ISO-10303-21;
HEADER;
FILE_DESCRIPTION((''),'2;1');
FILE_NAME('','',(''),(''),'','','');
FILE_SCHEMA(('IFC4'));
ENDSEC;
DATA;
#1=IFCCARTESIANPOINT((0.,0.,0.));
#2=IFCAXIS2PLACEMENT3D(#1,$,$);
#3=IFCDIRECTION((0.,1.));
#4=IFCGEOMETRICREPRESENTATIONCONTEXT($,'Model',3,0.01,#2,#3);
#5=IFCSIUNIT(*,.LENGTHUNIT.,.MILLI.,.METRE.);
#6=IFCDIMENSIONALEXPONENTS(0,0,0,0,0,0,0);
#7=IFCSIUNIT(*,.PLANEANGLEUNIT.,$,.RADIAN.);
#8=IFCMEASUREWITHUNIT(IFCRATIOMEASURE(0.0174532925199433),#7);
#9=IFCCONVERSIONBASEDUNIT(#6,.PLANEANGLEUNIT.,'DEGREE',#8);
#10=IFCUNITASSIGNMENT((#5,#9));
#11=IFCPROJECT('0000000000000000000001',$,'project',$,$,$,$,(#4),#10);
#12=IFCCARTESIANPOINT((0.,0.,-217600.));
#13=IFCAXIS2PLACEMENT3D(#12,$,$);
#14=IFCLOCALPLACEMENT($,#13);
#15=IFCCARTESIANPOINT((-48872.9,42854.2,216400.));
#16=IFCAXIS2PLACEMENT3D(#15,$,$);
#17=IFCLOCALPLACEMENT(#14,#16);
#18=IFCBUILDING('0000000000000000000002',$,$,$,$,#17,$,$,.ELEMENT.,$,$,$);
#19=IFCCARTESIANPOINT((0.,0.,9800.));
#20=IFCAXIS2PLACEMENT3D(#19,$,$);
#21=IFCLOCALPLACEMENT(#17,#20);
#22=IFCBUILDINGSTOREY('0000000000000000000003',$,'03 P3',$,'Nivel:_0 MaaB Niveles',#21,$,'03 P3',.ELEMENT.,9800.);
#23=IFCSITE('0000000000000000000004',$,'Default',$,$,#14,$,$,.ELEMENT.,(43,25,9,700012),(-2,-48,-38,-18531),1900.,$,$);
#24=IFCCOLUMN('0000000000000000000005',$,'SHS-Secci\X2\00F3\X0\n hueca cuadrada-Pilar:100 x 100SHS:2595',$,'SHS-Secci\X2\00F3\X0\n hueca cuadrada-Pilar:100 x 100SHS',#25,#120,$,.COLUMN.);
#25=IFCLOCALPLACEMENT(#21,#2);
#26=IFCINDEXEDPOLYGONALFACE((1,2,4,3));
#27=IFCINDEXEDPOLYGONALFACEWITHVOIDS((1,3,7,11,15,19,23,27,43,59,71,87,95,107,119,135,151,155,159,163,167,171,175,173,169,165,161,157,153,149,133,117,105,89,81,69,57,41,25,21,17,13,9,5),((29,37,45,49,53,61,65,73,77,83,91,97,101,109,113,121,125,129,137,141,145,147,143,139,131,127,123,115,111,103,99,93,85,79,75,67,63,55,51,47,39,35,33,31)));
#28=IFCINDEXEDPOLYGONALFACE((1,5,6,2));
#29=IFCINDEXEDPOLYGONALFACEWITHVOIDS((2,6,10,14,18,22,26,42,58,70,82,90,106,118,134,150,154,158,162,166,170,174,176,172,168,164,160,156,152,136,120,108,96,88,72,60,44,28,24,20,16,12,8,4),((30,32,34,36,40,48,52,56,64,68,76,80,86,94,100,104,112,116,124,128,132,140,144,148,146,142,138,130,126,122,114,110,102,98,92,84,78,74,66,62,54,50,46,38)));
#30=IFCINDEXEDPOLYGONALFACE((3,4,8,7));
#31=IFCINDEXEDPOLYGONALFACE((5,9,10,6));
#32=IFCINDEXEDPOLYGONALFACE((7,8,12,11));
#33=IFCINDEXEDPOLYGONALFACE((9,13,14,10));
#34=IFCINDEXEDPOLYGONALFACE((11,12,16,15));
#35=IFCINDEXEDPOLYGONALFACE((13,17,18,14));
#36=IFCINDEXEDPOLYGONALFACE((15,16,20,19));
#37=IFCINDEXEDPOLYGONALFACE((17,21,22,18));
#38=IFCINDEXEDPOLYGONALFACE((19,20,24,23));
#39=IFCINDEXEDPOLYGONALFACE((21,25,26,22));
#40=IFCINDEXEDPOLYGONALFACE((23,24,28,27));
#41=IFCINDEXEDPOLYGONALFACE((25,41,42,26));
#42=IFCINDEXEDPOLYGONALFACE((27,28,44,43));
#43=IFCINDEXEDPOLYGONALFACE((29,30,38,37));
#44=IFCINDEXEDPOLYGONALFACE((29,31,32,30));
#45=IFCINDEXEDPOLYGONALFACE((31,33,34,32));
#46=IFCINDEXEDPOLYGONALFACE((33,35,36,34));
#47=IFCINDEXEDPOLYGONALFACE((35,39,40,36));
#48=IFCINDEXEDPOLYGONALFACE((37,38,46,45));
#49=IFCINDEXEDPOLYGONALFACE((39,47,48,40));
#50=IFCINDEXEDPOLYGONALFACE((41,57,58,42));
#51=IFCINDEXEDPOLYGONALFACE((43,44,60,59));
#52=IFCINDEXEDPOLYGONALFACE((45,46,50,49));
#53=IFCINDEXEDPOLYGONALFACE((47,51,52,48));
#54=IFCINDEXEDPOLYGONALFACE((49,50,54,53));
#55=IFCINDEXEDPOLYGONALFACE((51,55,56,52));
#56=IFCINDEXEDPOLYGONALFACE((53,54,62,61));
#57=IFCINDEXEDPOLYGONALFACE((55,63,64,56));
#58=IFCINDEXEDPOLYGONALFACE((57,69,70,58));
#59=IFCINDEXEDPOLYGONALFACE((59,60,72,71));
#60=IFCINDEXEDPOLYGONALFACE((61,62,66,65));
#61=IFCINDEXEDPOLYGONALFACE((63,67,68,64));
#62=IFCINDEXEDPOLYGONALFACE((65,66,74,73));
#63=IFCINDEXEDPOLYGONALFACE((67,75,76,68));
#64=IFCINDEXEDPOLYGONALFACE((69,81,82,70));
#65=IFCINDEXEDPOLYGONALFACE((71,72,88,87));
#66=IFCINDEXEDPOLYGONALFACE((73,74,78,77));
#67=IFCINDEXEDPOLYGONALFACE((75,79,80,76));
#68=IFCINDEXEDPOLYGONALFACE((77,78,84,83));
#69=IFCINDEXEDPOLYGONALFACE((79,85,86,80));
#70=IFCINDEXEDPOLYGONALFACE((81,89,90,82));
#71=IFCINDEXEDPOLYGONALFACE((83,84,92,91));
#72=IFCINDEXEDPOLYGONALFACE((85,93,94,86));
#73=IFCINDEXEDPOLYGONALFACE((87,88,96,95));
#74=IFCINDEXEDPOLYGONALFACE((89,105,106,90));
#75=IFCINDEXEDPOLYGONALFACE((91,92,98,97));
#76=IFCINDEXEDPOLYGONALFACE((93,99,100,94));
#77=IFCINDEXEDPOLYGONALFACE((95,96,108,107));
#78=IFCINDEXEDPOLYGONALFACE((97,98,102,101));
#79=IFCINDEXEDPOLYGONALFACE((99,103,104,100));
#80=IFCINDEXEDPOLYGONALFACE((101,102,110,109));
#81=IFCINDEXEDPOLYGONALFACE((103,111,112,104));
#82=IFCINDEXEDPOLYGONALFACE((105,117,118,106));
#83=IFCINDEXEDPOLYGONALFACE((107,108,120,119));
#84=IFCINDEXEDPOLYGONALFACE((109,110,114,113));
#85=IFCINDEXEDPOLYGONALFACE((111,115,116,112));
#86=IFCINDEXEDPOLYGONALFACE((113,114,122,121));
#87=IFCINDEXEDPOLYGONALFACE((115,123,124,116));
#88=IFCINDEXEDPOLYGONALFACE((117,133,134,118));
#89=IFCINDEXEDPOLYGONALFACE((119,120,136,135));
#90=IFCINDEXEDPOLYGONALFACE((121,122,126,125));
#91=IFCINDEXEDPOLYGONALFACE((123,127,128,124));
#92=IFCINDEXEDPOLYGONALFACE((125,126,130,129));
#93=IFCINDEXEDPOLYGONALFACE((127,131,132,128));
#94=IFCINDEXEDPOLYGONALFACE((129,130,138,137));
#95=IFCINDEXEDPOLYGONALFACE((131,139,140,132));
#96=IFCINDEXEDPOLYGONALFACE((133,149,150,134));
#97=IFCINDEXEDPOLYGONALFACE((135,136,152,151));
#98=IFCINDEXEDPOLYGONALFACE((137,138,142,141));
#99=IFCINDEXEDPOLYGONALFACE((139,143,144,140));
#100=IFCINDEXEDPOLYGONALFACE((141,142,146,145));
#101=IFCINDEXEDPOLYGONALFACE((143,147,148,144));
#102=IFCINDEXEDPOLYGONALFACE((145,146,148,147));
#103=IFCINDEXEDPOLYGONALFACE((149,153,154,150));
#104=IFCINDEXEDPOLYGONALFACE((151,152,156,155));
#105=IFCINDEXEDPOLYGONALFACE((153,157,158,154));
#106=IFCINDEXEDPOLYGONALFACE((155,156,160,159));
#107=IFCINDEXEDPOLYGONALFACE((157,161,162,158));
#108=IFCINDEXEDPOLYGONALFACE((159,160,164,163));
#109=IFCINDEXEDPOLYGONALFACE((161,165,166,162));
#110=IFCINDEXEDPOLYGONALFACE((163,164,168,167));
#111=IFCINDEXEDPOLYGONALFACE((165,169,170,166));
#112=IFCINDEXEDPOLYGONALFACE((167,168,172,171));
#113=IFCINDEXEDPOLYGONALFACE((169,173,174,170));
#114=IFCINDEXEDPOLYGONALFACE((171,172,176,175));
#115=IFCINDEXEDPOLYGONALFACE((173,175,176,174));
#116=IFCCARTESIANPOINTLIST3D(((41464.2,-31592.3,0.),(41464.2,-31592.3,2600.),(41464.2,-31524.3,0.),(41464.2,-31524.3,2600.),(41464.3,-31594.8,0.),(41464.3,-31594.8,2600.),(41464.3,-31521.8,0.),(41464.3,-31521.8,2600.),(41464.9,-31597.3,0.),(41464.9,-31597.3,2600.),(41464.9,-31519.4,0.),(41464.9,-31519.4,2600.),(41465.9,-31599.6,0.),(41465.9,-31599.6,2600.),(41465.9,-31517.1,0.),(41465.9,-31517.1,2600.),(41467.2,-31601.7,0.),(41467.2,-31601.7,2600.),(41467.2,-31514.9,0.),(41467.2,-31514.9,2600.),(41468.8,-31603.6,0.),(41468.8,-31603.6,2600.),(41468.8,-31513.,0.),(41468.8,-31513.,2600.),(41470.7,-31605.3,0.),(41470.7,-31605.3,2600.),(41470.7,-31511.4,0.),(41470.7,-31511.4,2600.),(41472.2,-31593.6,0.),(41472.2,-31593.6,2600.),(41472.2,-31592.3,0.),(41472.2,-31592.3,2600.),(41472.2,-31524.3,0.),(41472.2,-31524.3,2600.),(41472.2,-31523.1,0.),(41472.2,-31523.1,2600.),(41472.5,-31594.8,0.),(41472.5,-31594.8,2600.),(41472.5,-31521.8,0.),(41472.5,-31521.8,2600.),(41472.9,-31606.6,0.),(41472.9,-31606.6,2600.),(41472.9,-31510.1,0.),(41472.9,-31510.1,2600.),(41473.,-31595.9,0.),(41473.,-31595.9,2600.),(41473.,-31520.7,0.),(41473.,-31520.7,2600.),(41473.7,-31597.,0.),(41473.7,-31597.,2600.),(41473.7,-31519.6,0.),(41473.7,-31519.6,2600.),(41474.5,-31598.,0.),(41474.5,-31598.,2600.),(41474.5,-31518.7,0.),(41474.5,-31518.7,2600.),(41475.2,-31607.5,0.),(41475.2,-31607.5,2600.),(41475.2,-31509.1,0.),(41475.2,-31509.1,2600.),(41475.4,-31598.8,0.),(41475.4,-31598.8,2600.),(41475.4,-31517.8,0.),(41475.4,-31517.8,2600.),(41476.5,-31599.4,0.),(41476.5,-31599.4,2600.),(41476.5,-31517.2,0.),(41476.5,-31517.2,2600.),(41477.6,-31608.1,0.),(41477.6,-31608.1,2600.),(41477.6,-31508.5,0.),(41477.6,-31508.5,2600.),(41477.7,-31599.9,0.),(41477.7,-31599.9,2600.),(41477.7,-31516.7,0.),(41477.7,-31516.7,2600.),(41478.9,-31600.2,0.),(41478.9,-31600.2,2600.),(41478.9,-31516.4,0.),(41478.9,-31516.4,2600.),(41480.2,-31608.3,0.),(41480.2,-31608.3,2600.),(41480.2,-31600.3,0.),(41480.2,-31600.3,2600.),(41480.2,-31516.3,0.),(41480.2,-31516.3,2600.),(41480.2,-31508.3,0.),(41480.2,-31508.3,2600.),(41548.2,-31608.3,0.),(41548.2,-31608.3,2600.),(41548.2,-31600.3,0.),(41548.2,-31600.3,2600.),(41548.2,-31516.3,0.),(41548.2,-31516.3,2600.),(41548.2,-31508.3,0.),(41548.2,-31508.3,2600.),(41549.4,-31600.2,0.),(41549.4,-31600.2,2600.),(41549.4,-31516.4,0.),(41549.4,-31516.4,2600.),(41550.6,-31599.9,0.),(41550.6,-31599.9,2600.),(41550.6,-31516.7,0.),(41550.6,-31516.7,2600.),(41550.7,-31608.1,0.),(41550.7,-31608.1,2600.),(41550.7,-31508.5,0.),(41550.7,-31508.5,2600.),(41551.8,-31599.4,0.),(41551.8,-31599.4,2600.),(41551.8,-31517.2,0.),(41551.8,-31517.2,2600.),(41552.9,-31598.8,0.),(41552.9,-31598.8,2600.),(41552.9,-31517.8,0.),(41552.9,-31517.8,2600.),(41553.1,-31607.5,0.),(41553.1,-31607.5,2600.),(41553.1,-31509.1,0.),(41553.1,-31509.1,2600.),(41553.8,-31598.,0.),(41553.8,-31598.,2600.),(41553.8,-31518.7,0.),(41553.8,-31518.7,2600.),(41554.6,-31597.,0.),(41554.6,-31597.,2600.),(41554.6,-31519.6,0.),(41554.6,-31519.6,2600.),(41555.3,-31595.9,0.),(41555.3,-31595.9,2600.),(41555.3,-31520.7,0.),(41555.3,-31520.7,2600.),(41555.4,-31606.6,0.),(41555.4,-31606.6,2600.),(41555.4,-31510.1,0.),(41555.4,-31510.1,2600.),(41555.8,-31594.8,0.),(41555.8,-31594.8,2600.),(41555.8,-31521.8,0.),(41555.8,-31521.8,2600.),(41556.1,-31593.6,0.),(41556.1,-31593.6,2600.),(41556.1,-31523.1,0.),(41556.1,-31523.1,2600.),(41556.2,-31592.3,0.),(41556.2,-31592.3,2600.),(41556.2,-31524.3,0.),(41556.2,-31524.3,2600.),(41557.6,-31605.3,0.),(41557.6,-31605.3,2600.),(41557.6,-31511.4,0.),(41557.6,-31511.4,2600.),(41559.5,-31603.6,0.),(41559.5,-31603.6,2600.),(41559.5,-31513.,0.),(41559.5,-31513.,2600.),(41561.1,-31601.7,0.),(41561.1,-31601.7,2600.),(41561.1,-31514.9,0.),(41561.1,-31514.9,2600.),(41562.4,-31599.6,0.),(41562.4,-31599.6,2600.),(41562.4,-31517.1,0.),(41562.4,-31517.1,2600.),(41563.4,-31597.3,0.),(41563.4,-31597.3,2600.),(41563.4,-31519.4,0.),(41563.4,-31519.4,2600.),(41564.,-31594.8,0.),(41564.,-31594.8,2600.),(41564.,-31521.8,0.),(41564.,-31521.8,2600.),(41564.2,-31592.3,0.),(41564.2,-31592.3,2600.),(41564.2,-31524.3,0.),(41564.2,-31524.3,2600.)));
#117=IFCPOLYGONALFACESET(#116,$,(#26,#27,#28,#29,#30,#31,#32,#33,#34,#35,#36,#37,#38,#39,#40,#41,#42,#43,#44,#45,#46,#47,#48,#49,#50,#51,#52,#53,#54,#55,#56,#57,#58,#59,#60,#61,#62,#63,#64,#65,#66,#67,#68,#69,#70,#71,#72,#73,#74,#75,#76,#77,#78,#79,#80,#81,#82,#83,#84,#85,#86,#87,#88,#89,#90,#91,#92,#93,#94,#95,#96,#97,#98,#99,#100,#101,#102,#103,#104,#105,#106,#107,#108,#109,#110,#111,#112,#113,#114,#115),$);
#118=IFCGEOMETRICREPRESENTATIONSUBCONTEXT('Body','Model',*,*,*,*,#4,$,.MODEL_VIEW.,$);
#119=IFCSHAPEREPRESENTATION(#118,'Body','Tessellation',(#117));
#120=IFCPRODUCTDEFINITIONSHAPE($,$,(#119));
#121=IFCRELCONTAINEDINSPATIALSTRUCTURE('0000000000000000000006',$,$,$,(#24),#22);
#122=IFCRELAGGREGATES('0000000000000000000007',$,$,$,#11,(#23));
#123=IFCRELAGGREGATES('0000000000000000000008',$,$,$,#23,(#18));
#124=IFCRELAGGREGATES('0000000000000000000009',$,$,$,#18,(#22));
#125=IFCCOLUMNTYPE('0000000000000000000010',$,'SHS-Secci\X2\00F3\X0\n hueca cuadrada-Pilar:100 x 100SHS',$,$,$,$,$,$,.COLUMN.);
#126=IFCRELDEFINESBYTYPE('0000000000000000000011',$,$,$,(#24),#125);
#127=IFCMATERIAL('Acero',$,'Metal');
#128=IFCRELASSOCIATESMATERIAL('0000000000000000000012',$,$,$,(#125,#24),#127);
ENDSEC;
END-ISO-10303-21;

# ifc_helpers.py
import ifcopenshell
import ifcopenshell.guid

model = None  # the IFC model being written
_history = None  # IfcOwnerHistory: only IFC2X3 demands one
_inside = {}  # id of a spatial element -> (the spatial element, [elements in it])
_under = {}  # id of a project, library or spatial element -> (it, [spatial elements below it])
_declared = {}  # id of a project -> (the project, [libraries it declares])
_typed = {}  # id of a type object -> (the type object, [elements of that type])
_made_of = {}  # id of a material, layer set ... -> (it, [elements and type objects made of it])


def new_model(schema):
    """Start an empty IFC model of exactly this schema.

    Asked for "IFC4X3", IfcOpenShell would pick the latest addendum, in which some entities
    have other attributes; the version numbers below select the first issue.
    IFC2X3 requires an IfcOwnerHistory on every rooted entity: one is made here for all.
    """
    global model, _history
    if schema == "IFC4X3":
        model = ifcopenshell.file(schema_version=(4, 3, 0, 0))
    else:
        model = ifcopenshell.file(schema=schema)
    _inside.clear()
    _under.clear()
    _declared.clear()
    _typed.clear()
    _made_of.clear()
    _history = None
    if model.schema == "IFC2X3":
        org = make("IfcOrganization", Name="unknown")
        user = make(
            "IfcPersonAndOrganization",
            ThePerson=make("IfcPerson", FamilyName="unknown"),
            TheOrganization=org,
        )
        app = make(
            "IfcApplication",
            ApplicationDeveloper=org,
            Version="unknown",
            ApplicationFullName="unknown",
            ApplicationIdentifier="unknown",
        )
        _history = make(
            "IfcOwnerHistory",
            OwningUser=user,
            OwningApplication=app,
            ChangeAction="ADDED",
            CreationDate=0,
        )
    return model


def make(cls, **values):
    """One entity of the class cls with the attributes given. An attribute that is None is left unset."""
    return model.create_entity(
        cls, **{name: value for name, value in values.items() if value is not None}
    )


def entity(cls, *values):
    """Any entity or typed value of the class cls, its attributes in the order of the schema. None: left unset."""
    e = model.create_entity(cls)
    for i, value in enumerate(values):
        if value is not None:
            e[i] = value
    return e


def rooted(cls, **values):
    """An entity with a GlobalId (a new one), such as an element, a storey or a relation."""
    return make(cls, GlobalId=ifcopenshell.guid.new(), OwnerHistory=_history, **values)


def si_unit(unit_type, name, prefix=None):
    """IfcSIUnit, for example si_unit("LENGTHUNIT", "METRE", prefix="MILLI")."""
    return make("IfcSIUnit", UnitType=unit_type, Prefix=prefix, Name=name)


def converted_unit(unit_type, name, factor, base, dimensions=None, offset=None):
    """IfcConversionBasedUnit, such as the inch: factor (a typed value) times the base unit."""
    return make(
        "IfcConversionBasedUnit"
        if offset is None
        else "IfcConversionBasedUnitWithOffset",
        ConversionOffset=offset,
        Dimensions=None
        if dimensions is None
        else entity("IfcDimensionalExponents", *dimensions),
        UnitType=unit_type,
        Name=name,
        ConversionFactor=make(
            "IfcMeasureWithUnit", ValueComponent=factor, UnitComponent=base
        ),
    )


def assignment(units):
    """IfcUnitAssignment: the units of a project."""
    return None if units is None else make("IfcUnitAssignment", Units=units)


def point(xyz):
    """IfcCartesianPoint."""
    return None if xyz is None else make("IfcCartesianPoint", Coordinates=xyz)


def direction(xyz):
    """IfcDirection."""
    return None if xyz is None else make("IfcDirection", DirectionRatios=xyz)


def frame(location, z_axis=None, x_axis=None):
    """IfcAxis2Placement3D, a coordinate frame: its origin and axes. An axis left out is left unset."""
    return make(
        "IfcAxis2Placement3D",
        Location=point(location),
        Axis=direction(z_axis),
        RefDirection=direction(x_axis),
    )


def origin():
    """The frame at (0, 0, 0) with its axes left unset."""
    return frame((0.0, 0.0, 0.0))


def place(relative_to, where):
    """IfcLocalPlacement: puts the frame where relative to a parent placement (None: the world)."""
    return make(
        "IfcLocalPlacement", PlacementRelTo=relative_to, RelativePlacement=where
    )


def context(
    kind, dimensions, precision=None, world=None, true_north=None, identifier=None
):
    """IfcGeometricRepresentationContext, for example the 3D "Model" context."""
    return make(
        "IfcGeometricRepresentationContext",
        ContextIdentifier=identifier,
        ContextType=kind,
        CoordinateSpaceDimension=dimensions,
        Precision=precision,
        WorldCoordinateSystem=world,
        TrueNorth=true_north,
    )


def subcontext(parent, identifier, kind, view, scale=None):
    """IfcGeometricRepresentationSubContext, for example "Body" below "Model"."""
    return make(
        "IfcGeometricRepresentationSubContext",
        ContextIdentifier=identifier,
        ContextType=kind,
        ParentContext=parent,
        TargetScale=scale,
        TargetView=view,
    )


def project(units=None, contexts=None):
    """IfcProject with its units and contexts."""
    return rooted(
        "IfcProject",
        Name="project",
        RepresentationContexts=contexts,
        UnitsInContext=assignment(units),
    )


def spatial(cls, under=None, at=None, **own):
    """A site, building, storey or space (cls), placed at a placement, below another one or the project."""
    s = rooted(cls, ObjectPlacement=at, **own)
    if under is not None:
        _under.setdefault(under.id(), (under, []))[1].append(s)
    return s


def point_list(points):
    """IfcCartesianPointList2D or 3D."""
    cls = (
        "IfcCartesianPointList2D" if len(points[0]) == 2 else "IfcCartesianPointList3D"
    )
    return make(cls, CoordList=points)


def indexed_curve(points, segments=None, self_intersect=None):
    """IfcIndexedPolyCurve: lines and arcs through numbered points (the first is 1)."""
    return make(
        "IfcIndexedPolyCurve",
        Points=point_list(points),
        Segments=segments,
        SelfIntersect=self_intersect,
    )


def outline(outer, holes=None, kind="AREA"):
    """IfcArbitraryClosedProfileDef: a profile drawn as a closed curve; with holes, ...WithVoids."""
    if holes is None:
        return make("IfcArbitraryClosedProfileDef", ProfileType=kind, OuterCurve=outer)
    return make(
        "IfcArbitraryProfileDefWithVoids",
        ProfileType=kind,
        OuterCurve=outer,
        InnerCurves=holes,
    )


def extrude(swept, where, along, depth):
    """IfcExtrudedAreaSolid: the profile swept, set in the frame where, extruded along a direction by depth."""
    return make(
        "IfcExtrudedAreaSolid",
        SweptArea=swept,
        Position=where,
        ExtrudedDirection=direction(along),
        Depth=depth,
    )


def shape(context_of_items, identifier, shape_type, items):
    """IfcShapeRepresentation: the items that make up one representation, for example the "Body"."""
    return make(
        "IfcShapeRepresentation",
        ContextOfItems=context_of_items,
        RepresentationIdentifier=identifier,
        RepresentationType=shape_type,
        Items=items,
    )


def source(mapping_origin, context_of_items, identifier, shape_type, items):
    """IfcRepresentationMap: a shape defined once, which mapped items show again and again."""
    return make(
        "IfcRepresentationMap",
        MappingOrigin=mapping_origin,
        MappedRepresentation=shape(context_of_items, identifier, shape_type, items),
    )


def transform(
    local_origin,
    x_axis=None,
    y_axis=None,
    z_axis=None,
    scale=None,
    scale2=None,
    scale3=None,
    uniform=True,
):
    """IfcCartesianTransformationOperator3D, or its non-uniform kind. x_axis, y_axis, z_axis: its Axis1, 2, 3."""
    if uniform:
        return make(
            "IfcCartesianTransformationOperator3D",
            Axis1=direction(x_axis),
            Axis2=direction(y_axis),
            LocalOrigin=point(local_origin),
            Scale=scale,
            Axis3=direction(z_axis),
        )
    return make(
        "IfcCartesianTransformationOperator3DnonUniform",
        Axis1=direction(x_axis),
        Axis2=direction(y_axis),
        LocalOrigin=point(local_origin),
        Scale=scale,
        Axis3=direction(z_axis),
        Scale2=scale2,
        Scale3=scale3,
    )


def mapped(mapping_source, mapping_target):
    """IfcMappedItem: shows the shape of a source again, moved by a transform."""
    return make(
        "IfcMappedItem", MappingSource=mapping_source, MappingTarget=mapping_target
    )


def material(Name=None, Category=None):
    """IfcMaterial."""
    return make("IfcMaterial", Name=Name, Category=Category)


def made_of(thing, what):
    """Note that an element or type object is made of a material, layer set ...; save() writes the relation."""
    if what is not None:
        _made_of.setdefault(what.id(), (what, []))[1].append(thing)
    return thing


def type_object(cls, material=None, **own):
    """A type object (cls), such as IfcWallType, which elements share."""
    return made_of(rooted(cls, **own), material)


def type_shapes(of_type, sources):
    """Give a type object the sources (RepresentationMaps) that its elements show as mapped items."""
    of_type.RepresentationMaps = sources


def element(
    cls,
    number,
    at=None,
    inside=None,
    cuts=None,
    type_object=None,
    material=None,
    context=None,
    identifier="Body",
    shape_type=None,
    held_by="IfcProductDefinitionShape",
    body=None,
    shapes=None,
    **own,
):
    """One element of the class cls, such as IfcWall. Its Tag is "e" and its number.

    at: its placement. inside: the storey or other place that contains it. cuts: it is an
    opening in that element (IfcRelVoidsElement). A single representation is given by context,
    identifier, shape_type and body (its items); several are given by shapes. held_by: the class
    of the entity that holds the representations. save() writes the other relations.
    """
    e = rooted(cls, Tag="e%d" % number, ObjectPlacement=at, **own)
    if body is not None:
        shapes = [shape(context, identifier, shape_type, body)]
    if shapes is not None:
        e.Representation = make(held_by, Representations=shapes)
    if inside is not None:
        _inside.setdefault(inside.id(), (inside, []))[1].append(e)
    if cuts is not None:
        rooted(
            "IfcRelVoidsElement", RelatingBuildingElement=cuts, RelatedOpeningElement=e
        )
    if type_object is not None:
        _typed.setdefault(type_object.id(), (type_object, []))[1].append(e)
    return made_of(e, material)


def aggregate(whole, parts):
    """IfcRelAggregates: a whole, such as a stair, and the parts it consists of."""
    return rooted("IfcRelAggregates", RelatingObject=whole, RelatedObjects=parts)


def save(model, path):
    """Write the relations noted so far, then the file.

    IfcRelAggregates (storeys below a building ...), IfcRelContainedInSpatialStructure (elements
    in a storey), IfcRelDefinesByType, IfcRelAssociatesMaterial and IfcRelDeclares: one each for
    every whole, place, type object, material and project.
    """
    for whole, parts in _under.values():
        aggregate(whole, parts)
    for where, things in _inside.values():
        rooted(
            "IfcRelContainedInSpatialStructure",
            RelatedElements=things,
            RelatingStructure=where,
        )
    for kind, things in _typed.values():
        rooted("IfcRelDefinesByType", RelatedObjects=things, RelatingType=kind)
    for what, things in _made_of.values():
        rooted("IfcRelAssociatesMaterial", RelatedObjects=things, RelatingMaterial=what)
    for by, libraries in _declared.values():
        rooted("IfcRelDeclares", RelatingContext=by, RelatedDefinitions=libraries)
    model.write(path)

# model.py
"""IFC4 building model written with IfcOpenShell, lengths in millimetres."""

from ifc_helpers import new_model, entity, si_unit, converted_unit, direction, frame, origin, place, context, subcontext, project, spatial, indexed_curve, outline, extrude, source, transform, mapped, material, type_object, type_shapes, element, save


model = new_model("IFC4")

# Units and contexts
model_context = context("Model", 3, precision=0.01, world=origin(), true_north=direction((0.0, 1.0)))
body_context = subcontext(model_context, "Body", "Model", "MODEL_VIEW")
ifc_project = project(units=[si_unit("LENGTHUNIT", "METRE", prefix="MILLI"), converted_unit("PLANEANGLEUNIT", "DEGREE", entity("IfcRatioMeasure", 0.0174532925199433), si_unit("PLANEANGLEUNIT", "RADIAN"), dimensions=[0, 0, 0, 0, 0, 0, 0])], contexts=[model_context])

# Site, building, storey
site_placement = place(None, frame((0.0, 0.0, -217600.0)))
site = spatial("IfcSite", under=ifc_project, at=site_placement, Name="Default", CompositionType="ELEMENT", RefLatitude=(43, 25, 9, 700012), RefLongitude=(-2, -48, -38, -18531), RefElevation=1900.0)
building_placement = place(site_placement, frame((-48872.9, 42854.2, 216400.0)))
building = spatial("IfcBuilding", under=site, at=building_placement, CompositionType="ELEMENT")
storey_placement = place(building_placement, frame((0.0, 0.0, 9800.0)))
storey = spatial("IfcBuildingStorey", under=building, at=storey_placement, Name="03 P3", ObjectType="Nivel:_0 MaaB Niveles", LongName="03 P3", CompositionType="ELEMENT", Elevation=9800.0)

# Column
ifc_material_1 = material(Name="Acero", Category="Metal")
column_type_1 = type_object("IfcColumnType", Name="SHS-Sección hueca cuadrada-Pilar:100 x 100SHS", PredefinedType="COLUMN", material=ifc_material_1)
shared_shape_1 = source(origin(), body_context, "Body", "SweptSolid", [
    extrude(outline(indexed_curve([(-34.0, -50.0), (34.0, -50.0), (36.5, -49.8), (38.9, -49.2), (41.3, -48.3), (43.4, -46.9), (45.3, -45.3), (46.9, -43.4), (48.3, -41.3), (49.2, -38.9), (49.8, -36.5), (50.0, -34.0), (50.0, 34.0), (49.8, 36.5), (49.2, 38.9), (48.3, 41.3), (46.9, 43.4), (45.3, 45.3), (43.4, 46.9), (41.3, 48.3), (38.9, 49.2), (36.5, 49.8), (34.0, 50.0), (-34.0, 50.0), (-36.5, 49.8), (-38.9, 49.2), (-41.3, 48.3), (-43.4, 46.9), (-45.3, 45.3), (-46.9, 43.4), (-48.3, 41.3), (-49.2, 38.9), (-49.8, 36.5), (-50.0, 34.0), (-50.0, -34.0), (-49.8, -36.5), (-49.2, -38.9), (-48.3, -41.3), (-46.9, -43.4), (-45.3, -45.3), (-43.4, -46.9), (-41.3, -48.3), (-38.9, -49.2), (-36.5, -49.8), (-34.0, -50.0)], self_intersect=False), holes=[indexed_curve([(-42.0, 34.0), (-41.9, 35.3), (-41.6, 36.5), (-41.1, 37.6), (-40.5, 38.7), (-39.7, 39.7), (-38.7, 40.5), (-37.6, 41.1), (-36.5, 41.6), (-35.3, 41.9), (-34.0, 42.0), (34.0, 42.0), (35.3, 41.9), (36.5, 41.6), (37.6, 41.1), (38.7, 40.5), (39.7, 39.7), (40.5, 38.7), (41.1, 37.6), (41.6, 36.5), (41.9, 35.3), (42.0, 34.0), (42.0, -34.0), (41.9, -35.3), (41.6, -36.5), (41.1, -37.6), (40.5, -38.7), (39.7, -39.7), (38.7, -40.5), (37.6, -41.1), (36.5, -41.6), (35.3, -41.9), (34.0, -42.0), (-34.0, -42.0), (-35.3, -41.9), (-36.5, -41.6), (-37.6, -41.1), (-38.7, -40.5), (-39.7, -39.7), (-40.5, -38.7), (-41.1, -37.6), (-41.6, -36.5), (-41.9, -35.3), (-42.0, -34.0), (-42.0, 34.0)], self_intersect=False)]), frame((0.0, 0.0, 9800.0), z_axis=(0.0, 0.0, 1.0), x_axis=(0.0, 1.0, 0.0)), (0.0, 0.0, 1.0), 2600.0),
])
type_shapes(column_type_1, [shared_shape_1])
column_1_placement = place(storey_placement, frame((41514.2, -31558.3, -9800.0), z_axis=(0.0, 0.0, 1.0), x_axis=(0.0, -1.0, 0.0)))
element("IfcColumn", 1, at=column_1_placement, inside=storey, type_object=column_type_1, material=ifc_material_1, Name="SHS-Sección hueca cuadrada-Pilar:100 x 100SHS:2595", ObjectType="SHS-Sección hueca cuadrada-Pilar:100 x 100SHS", PredefinedType="COLUMN", context=body_context, shape_type="MappedRepresentation", body=[
    mapped(shared_shape_1, transform((0.0, 0.0, 0.0), scale=1.0)),
])

save(model, "model.ifc")
